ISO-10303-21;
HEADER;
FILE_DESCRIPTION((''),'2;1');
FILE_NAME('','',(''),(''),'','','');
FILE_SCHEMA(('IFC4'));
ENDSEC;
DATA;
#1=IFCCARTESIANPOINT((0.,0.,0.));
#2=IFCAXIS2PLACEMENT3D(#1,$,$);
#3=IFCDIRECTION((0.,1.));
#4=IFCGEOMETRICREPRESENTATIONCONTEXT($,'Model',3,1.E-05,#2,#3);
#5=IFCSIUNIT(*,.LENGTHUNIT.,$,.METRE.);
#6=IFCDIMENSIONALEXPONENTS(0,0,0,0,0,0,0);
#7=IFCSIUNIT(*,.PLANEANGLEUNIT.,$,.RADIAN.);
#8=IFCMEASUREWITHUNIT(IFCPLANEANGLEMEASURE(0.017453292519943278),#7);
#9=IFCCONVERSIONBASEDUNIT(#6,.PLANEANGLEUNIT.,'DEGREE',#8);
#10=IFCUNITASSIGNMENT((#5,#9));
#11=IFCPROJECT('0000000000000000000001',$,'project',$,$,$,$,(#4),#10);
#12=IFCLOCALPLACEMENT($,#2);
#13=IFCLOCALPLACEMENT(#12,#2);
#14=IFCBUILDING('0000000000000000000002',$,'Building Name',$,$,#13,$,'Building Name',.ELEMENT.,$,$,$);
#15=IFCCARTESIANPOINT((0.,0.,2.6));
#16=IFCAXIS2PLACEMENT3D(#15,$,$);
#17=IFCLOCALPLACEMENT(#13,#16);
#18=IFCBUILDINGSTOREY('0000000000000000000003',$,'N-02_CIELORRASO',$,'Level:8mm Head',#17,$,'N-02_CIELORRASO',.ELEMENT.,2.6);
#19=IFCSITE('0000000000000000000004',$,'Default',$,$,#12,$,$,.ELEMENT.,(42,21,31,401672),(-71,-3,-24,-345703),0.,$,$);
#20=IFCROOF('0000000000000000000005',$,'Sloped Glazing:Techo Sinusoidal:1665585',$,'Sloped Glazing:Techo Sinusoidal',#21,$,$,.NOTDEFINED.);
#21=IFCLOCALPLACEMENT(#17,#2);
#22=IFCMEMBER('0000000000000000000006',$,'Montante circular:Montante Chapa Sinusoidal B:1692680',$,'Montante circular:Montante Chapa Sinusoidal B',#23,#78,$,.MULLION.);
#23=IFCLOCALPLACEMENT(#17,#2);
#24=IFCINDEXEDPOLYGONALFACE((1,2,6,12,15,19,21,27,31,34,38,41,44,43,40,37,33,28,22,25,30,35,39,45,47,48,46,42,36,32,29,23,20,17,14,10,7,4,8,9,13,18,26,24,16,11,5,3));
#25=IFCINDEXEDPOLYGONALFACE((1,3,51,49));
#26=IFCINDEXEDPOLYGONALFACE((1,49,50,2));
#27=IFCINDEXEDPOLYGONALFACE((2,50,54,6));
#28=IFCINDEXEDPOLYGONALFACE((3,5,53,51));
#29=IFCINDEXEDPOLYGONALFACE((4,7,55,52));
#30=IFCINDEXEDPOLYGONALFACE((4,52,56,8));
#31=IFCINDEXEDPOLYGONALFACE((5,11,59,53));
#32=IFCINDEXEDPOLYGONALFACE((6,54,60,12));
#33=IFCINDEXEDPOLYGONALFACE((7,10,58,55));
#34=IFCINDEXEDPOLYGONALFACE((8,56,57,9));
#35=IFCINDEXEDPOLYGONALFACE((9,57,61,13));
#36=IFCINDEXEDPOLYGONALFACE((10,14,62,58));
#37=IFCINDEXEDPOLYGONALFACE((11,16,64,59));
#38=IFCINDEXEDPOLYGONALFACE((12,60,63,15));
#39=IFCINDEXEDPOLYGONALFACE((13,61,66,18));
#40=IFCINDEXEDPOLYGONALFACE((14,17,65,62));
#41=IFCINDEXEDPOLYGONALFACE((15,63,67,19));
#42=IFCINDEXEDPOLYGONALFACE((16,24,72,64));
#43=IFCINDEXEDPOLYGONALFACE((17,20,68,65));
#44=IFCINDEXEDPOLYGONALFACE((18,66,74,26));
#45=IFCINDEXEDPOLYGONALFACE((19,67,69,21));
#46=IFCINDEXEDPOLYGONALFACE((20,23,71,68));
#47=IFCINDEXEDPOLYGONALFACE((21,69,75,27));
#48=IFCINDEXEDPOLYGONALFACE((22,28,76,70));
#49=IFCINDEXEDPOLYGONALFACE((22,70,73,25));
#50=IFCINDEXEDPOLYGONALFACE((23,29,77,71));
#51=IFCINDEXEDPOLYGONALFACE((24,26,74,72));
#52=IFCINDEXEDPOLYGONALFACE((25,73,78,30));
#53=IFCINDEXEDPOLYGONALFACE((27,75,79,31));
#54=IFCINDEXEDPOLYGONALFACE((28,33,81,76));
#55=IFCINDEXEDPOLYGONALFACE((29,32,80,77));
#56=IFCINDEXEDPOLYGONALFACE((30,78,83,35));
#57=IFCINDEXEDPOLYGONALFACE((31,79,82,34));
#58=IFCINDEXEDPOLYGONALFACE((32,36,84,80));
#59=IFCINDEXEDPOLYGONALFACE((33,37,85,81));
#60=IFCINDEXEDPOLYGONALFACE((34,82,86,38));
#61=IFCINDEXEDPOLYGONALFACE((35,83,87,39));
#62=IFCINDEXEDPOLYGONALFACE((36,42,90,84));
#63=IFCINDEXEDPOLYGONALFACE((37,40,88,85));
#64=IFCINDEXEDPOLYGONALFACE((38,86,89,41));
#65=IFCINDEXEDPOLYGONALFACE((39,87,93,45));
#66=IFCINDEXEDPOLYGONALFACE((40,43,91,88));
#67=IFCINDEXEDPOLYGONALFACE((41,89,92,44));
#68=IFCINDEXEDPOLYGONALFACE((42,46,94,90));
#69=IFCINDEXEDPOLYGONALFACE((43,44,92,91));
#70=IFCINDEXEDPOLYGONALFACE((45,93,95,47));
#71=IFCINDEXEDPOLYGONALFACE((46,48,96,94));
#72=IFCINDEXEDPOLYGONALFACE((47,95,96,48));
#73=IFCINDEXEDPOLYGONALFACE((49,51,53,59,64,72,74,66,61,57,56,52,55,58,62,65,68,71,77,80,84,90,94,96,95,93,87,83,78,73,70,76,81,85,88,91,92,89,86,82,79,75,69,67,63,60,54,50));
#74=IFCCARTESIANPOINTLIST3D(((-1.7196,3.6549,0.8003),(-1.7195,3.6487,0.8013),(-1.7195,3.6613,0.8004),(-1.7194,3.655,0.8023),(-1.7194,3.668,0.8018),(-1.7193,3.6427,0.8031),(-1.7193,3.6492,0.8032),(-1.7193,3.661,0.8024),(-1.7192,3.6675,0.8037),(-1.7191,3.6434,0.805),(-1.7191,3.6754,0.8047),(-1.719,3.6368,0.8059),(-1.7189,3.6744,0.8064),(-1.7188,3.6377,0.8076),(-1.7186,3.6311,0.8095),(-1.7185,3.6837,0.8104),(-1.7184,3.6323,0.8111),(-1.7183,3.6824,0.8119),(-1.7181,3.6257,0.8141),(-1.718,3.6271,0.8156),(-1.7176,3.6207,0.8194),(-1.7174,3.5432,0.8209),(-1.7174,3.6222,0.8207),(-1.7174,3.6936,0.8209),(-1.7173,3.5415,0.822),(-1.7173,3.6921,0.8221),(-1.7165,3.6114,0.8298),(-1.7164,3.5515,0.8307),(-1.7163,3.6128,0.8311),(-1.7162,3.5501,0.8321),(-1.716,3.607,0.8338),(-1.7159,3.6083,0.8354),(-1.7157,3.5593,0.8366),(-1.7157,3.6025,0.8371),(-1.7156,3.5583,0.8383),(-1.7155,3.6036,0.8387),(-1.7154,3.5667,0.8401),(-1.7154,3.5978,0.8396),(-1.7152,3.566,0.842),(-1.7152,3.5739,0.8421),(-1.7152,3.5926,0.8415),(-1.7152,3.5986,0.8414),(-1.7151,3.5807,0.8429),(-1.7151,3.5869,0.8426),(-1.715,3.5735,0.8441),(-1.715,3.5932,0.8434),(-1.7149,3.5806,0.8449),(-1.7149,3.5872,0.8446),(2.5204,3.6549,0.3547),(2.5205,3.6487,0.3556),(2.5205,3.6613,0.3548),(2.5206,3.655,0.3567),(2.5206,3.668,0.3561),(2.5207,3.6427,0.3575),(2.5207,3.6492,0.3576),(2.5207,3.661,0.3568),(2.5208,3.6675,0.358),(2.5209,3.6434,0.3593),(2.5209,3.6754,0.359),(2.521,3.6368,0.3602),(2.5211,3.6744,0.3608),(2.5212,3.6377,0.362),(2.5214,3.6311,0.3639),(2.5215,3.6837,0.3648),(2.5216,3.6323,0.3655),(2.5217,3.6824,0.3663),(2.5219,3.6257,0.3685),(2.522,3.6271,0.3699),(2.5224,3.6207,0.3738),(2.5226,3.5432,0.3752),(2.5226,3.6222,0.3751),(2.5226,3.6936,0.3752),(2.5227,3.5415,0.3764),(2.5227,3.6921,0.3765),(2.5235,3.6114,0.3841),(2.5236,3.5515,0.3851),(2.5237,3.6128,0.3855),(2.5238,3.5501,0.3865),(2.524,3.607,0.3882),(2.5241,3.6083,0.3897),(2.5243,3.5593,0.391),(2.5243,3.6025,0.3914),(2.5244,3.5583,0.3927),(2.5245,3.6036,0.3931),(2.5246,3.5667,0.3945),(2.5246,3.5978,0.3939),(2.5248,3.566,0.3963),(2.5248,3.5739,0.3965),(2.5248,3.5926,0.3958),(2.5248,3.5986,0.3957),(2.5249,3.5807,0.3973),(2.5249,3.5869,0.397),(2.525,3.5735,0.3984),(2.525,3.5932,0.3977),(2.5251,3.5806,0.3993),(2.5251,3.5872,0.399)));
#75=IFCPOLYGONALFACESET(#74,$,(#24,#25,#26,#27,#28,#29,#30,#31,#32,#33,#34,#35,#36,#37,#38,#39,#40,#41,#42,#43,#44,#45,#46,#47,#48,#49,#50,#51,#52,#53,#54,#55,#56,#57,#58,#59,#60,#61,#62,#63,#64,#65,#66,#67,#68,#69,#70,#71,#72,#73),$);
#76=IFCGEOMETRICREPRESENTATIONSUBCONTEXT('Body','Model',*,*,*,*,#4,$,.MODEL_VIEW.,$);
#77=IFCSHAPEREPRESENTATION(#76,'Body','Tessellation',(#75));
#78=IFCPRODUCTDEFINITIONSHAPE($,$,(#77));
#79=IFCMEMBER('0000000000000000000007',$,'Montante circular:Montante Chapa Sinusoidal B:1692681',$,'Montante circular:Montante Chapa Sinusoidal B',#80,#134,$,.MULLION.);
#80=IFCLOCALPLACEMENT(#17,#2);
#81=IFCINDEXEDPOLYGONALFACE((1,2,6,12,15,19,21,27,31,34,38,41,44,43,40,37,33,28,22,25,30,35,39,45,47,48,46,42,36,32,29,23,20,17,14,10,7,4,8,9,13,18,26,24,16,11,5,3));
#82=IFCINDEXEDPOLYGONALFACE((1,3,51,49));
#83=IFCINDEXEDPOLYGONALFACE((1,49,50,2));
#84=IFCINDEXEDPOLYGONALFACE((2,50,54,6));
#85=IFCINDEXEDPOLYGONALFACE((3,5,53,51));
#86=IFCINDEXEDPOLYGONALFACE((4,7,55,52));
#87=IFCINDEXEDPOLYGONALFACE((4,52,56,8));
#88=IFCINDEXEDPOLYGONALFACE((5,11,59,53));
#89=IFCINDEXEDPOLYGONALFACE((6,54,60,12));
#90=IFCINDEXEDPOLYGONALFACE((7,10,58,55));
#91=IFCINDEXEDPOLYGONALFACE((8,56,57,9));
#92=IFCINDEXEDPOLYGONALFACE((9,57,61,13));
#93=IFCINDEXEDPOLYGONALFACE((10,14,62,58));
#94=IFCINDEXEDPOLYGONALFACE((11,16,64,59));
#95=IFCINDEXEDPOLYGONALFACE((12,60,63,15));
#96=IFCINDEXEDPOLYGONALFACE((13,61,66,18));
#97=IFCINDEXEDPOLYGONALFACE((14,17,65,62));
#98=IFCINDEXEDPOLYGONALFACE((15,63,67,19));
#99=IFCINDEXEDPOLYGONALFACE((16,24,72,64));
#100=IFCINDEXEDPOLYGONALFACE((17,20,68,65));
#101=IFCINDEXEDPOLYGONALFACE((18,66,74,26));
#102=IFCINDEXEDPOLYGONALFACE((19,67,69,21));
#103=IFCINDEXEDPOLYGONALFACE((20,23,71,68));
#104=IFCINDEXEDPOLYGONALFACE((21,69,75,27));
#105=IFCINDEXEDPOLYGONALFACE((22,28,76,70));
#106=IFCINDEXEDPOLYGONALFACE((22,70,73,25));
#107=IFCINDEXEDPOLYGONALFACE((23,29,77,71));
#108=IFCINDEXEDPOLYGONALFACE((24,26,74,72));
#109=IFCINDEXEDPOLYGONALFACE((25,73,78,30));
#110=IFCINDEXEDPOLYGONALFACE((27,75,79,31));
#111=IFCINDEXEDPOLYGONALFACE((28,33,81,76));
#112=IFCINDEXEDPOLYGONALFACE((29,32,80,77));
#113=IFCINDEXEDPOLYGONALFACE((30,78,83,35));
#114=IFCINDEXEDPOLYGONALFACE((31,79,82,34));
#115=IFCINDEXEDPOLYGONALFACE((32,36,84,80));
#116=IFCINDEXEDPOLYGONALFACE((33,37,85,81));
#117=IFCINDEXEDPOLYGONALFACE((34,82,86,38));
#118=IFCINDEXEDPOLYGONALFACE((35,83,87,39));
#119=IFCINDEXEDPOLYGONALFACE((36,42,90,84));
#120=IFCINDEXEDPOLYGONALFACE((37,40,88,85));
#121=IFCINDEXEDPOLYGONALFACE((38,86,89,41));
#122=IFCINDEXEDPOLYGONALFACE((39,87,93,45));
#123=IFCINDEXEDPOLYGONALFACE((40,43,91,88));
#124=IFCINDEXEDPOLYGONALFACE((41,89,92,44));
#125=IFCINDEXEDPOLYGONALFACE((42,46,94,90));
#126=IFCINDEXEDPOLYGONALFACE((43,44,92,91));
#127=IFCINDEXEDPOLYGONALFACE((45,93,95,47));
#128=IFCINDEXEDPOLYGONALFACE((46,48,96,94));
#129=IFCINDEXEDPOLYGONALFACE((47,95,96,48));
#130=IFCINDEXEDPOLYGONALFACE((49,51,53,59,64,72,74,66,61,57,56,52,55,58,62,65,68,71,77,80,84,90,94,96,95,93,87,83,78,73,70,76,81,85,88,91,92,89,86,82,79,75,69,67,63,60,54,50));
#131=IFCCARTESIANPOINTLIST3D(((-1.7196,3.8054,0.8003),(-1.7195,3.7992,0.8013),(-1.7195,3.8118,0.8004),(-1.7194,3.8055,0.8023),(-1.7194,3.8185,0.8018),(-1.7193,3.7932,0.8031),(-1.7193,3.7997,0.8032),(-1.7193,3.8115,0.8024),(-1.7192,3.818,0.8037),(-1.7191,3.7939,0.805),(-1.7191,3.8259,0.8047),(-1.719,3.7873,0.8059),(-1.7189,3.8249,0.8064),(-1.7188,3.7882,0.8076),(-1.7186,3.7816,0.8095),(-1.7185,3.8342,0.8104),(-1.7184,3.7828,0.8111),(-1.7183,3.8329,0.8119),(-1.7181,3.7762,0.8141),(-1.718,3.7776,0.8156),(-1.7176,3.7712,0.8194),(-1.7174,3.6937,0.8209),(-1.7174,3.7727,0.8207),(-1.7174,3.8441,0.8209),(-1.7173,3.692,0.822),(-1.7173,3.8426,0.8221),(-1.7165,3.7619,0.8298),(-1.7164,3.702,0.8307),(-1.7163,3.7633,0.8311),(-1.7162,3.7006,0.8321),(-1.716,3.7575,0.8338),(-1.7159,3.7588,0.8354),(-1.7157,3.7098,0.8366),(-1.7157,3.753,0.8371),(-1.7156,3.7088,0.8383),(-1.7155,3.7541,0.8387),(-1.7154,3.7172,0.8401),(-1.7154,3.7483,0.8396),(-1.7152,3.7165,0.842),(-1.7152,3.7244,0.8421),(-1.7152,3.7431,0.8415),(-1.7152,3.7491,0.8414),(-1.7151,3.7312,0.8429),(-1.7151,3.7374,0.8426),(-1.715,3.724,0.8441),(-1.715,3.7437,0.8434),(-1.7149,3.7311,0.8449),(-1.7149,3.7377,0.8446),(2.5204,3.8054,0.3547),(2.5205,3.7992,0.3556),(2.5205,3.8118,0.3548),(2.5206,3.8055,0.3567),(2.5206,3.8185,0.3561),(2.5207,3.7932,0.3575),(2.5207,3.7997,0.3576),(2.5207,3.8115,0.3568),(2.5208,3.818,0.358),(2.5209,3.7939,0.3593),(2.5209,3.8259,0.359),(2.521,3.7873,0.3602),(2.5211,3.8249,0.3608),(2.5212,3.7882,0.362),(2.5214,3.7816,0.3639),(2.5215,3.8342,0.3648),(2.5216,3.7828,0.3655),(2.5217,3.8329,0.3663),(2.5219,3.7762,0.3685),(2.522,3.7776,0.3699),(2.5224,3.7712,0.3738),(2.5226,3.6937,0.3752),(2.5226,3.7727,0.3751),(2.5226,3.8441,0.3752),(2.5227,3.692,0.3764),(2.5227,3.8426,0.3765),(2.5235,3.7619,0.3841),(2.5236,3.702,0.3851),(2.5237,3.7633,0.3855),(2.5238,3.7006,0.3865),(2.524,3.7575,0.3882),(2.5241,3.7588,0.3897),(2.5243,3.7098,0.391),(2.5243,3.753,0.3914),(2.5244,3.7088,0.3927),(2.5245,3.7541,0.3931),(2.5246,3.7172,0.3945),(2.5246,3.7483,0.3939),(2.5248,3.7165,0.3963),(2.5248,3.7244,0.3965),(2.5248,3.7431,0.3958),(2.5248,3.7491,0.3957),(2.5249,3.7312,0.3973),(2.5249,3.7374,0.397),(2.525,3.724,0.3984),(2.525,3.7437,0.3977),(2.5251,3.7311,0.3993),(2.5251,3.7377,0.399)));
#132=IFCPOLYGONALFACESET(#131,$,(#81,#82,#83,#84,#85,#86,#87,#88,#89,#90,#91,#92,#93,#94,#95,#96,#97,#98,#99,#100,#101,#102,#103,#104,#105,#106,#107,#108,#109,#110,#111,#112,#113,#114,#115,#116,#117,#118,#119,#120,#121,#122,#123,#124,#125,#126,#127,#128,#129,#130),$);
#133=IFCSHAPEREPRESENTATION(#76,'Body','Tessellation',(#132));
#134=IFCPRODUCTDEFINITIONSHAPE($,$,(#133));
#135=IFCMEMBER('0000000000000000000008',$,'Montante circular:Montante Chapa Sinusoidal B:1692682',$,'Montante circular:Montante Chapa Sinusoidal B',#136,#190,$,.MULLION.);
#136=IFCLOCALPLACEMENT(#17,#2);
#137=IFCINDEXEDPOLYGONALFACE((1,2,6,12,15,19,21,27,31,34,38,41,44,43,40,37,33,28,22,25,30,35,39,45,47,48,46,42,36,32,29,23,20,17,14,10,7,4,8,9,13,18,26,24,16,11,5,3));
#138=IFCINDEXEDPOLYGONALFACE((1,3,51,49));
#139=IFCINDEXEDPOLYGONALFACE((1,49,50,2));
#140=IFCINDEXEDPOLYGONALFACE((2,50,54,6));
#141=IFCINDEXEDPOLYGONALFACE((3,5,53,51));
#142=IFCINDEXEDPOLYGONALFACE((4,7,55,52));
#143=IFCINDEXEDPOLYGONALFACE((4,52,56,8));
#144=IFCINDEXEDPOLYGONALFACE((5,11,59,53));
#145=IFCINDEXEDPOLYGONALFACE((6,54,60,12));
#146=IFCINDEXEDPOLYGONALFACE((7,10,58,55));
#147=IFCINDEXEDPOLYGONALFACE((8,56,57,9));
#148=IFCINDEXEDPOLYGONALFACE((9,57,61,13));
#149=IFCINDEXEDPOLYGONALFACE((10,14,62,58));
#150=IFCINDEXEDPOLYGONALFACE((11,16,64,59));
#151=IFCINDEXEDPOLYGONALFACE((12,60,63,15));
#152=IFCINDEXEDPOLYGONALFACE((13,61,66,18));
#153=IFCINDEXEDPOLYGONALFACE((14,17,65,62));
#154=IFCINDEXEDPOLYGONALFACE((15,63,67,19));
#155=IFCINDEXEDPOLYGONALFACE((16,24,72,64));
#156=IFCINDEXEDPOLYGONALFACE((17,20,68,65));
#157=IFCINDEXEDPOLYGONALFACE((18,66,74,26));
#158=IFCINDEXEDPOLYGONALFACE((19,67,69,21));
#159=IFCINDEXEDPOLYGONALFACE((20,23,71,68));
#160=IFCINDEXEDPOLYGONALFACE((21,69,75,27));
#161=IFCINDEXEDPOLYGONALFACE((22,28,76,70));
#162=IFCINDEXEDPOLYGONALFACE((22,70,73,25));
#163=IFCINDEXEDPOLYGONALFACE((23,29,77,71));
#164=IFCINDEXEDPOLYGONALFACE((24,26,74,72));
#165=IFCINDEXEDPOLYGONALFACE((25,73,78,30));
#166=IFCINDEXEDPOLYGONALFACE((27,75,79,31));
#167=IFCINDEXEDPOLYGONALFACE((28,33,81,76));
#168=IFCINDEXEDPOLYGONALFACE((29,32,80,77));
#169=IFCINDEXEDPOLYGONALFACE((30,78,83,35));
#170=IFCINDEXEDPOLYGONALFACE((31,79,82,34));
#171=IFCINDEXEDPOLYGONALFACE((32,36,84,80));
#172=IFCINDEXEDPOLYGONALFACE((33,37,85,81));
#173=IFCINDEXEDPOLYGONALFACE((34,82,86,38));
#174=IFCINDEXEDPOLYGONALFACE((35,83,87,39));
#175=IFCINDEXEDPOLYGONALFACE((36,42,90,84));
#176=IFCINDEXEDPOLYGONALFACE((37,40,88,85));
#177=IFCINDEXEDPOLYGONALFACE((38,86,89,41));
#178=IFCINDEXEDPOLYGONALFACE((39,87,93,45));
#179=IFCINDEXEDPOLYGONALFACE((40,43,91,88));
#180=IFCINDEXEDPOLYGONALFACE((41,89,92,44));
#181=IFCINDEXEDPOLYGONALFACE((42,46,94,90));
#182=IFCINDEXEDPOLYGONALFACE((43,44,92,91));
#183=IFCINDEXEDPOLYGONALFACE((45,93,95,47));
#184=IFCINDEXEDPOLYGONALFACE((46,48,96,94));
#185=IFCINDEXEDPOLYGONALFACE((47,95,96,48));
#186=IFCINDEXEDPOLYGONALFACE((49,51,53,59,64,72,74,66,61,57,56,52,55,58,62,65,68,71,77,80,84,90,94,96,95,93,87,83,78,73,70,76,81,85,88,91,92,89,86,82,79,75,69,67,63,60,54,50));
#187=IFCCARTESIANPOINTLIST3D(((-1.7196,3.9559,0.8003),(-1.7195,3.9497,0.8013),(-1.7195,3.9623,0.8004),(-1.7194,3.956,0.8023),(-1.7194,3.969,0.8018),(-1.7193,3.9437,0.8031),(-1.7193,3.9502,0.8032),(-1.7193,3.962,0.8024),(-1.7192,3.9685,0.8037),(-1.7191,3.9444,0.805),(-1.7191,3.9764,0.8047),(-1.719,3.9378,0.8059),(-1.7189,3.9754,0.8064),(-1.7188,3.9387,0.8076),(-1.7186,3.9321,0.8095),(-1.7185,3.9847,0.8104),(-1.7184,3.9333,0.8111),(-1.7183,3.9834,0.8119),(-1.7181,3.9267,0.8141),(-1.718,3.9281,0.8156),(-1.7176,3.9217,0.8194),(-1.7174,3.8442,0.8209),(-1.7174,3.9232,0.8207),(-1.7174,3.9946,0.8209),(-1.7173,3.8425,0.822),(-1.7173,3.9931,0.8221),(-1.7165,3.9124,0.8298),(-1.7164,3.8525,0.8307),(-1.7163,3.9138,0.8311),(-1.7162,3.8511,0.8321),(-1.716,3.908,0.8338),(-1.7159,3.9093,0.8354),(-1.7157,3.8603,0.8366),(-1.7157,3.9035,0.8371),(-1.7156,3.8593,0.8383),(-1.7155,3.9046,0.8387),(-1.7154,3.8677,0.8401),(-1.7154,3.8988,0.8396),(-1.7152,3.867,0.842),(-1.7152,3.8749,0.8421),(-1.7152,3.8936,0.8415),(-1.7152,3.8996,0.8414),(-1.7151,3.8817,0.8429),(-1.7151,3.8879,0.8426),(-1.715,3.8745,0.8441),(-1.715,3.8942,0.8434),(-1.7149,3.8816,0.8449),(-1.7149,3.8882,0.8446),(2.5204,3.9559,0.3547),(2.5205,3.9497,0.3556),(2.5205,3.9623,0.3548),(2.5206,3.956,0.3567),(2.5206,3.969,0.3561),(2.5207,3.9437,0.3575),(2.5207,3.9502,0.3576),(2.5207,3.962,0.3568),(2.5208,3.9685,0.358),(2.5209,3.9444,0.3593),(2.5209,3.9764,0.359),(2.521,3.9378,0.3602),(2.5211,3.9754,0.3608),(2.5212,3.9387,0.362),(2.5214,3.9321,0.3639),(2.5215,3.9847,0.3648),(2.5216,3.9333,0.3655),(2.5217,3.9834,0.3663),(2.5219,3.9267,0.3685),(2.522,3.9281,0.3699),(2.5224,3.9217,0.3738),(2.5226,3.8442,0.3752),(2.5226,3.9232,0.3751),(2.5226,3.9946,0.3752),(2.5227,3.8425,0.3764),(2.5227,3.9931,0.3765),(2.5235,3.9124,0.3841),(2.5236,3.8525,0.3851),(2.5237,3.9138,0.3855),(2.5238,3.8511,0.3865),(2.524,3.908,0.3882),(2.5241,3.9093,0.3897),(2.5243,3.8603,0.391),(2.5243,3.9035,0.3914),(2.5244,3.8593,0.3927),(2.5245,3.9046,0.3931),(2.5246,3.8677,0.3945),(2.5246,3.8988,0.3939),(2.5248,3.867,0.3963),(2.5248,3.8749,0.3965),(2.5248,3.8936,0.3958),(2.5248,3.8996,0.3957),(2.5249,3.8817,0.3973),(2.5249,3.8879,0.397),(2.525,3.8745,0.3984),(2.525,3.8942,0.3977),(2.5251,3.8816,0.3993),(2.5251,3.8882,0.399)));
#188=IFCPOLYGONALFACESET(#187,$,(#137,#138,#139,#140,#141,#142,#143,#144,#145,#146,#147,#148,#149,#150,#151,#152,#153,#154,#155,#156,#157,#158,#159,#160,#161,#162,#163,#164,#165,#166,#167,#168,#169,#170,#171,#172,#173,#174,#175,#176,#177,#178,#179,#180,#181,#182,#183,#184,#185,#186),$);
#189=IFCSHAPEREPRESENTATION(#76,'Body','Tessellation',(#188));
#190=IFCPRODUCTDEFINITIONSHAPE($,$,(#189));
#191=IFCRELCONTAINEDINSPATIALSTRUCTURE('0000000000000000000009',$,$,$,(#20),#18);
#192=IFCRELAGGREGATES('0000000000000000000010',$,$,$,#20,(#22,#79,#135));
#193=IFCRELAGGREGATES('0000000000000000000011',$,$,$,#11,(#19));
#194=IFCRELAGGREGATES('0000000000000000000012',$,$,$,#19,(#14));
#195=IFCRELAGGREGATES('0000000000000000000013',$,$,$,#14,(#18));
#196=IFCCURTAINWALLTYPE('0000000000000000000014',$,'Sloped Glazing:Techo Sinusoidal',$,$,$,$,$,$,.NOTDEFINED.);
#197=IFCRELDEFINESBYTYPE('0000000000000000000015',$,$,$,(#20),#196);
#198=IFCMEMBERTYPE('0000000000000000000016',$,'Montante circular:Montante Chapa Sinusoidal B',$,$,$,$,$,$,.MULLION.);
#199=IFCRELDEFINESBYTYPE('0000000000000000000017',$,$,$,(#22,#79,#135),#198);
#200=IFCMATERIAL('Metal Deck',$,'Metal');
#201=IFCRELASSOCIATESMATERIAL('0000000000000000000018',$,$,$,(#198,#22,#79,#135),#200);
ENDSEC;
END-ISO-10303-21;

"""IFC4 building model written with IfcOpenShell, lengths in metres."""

from ifc_helpers import new_model, entity, si_unit, converted_unit, direction, frame, origin, place, context, subcontext, project, spatial, indexed_curve, outline, extrude, source, transform, mapped, material, type_object, type_shapes, element, aggregate, save


model = new_model("IFC4")

# Units and contexts
model_context = context("Model", 3, precision=1e-05, world=origin(), true_north=direction((0.0, 1.0)))
body_context = subcontext(model_context, "Body", "Model", "MODEL_VIEW")
ifc_project = project(units=[si_unit("LENGTHUNIT", "METRE"), converted_unit("PLANEANGLEUNIT", "DEGREE", entity("IfcPlaneAngleMeasure", 0.017453292519943278), si_unit("PLANEANGLEUNIT", "RADIAN"), dimensions=[0, 0, 0, 0, 0, 0, 0])], contexts=[model_context])

# Site, building, storey
site_placement = place(None, origin())
site = spatial("IfcSite", under=ifc_project, at=site_placement, Name="Default", CompositionType="ELEMENT", RefLatitude=(42, 21, 31, 401672), RefLongitude=(-71, -3, -24, -345703), RefElevation=0.0)
building_placement = place(site_placement, origin())
building = spatial("IfcBuilding", under=site, at=building_placement, Name="Building Name", LongName="Building Name", CompositionType="ELEMENT")
storey_placement = place(building_placement, frame((0.0, 0.0, 2.6)))
storey = spatial("IfcBuildingStorey", under=building, at=storey_placement, Name="N-02_CIELORRASO", ObjectType="Level:8mm Head", LongName="N-02_CIELORRASO", CompositionType="ELEMENT", Elevation=2.6)

# Roof, members
curtain_wall_type = type_object("IfcCurtainWallType", Name="Sloped Glazing:Techo Sinusoidal", PredefinedType="NOTDEFINED")
roof_placement = place(storey_placement, frame((0.0, 0.0, -2.6)))
roof = element("IfcRoof", 1, at=roof_placement, inside=storey, type_object=curtain_wall_type, Name="Sloped Glazing:Techo Sinusoidal:1665585", ObjectType="Sloped Glazing:Techo Sinusoidal", PredefinedType="NOTDEFINED")
ifc_material = material(Name="Metal Deck", Category="Metal")
member_type = type_object("IfcMemberType", Name="Montante circular:Montante Chapa Sinusoidal B", PredefinedType="MULLION", material=ifc_material)
shared_shape = source(origin(), body_context, "Body", "SweptSolid", [
    extrude(outline(indexed_curve([(0.0595, -0.0443), (0.0615, -0.0443), (0.0603, -0.031), (0.0572, -0.0213), (0.053, -0.0138), (0.0481, -0.0078), (0.0427, -0.003), (0.0372, 0.0005), (0.0315, 0.0029), (0.0259, 0.0044), (0.0203, 0.0051), (0.0146, 0.005), (0.0084, 0.0041), (-0.0053, 0.0009), (-0.0123, -0.0005), (-0.0191, -0.0012), (-0.0256, -0.001), (-0.0317, 0.0001), (-0.0375, 0.0019), (-0.0428, 0.0046), (-0.0477, 0.0081), (-0.0522, 0.0128), (-0.0563, 0.0191), (-0.0597, 0.0282), (-0.0617, 0.0421), (-0.0637, 0.042), (-0.0616, 0.0277), (-0.0581, 0.0182), (-0.0537, 0.0116), (-0.049, 0.0066), (-0.0438, 0.0028), (-0.0382, 0.0001), (-0.0322, -0.0019), (-0.0258, -0.003), (-0.019, -0.0032), (-0.012, -0.0025), (-0.0048, -0.0011), (0.0088, 0.0021), (0.0147, 0.003), (0.0202, 0.0031), (0.0255, 0.0024), (0.0309, 0.001), (0.0362, -0.0013), (0.0415, -0.0046), (0.0466, -0.0092), (0.0513, -0.0149), (0.0554, -0.0221), (0.0584, -0.0314), (0.0595, -0.0443)], self_intersect=False)), frame((-0.007, 0.0228, -4.2634), z_axis=(0.0, 0.0, 1.0), x_axis=(-0.819152, -0.573576, 0.0)), (0.0, 0.0, 1.0), 4.2634),
])
type_shapes(member_type, [shared_shape])
member_1_placement = place(roof_placement, frame((-1.7148, 3.6244, 3.4456), z_axis=(-0.994522, 0.0, 0.104528), x_axis=(0.0, 1.0, 0.0)))
member_1 = element("IfcMember", 2, at=member_1_placement, type_object=member_type, material=ifc_material, Name="Montante circular:Montante Chapa Sinusoidal B:1692680", ObjectType="Montante circular:Montante Chapa Sinusoidal B", PredefinedType="MULLION", context=body_context, shape_type="MappedRepresentation", body=[
    mapped(shared_shape, transform((0.0, 0.0, 0.0), scale=1.0)),
])
member_2_placement = place(roof_placement, frame((-1.7148, 3.7749, 3.4456), z_axis=(-0.994522, 0.0, 0.104528), x_axis=(0.0, 1.0, 0.0)))
member_2 = element("IfcMember", 3, at=member_2_placement, type_object=member_type, material=ifc_material, Name="Montante circular:Montante Chapa Sinusoidal B:1692681", ObjectType="Montante circular:Montante Chapa Sinusoidal B", PredefinedType="MULLION", context=body_context, shape_type="MappedRepresentation", body=[
    mapped(shared_shape, transform((0.0, 0.0, 0.0), scale=1.0)),
])
member_3_placement = place(roof_placement, frame((-1.7148, 3.9254, 3.4456), z_axis=(-0.994522, 0.0, 0.104528), x_axis=(0.0, 1.0, 0.0)))
member_3 = element("IfcMember", 4, at=member_3_placement, type_object=member_type, material=ifc_material, Name="Montante circular:Montante Chapa Sinusoidal B:1692682", ObjectType="Montante circular:Montante Chapa Sinusoidal B", PredefinedType="MULLION", context=body_context, shape_type="MappedRepresentation", body=[
    mapped(shared_shape, transform((0.0, 0.0, 0.0), scale=1.0)),
])
aggregate(roof, [member_1, member_2, member_3])

save(model, "model.ifc")
